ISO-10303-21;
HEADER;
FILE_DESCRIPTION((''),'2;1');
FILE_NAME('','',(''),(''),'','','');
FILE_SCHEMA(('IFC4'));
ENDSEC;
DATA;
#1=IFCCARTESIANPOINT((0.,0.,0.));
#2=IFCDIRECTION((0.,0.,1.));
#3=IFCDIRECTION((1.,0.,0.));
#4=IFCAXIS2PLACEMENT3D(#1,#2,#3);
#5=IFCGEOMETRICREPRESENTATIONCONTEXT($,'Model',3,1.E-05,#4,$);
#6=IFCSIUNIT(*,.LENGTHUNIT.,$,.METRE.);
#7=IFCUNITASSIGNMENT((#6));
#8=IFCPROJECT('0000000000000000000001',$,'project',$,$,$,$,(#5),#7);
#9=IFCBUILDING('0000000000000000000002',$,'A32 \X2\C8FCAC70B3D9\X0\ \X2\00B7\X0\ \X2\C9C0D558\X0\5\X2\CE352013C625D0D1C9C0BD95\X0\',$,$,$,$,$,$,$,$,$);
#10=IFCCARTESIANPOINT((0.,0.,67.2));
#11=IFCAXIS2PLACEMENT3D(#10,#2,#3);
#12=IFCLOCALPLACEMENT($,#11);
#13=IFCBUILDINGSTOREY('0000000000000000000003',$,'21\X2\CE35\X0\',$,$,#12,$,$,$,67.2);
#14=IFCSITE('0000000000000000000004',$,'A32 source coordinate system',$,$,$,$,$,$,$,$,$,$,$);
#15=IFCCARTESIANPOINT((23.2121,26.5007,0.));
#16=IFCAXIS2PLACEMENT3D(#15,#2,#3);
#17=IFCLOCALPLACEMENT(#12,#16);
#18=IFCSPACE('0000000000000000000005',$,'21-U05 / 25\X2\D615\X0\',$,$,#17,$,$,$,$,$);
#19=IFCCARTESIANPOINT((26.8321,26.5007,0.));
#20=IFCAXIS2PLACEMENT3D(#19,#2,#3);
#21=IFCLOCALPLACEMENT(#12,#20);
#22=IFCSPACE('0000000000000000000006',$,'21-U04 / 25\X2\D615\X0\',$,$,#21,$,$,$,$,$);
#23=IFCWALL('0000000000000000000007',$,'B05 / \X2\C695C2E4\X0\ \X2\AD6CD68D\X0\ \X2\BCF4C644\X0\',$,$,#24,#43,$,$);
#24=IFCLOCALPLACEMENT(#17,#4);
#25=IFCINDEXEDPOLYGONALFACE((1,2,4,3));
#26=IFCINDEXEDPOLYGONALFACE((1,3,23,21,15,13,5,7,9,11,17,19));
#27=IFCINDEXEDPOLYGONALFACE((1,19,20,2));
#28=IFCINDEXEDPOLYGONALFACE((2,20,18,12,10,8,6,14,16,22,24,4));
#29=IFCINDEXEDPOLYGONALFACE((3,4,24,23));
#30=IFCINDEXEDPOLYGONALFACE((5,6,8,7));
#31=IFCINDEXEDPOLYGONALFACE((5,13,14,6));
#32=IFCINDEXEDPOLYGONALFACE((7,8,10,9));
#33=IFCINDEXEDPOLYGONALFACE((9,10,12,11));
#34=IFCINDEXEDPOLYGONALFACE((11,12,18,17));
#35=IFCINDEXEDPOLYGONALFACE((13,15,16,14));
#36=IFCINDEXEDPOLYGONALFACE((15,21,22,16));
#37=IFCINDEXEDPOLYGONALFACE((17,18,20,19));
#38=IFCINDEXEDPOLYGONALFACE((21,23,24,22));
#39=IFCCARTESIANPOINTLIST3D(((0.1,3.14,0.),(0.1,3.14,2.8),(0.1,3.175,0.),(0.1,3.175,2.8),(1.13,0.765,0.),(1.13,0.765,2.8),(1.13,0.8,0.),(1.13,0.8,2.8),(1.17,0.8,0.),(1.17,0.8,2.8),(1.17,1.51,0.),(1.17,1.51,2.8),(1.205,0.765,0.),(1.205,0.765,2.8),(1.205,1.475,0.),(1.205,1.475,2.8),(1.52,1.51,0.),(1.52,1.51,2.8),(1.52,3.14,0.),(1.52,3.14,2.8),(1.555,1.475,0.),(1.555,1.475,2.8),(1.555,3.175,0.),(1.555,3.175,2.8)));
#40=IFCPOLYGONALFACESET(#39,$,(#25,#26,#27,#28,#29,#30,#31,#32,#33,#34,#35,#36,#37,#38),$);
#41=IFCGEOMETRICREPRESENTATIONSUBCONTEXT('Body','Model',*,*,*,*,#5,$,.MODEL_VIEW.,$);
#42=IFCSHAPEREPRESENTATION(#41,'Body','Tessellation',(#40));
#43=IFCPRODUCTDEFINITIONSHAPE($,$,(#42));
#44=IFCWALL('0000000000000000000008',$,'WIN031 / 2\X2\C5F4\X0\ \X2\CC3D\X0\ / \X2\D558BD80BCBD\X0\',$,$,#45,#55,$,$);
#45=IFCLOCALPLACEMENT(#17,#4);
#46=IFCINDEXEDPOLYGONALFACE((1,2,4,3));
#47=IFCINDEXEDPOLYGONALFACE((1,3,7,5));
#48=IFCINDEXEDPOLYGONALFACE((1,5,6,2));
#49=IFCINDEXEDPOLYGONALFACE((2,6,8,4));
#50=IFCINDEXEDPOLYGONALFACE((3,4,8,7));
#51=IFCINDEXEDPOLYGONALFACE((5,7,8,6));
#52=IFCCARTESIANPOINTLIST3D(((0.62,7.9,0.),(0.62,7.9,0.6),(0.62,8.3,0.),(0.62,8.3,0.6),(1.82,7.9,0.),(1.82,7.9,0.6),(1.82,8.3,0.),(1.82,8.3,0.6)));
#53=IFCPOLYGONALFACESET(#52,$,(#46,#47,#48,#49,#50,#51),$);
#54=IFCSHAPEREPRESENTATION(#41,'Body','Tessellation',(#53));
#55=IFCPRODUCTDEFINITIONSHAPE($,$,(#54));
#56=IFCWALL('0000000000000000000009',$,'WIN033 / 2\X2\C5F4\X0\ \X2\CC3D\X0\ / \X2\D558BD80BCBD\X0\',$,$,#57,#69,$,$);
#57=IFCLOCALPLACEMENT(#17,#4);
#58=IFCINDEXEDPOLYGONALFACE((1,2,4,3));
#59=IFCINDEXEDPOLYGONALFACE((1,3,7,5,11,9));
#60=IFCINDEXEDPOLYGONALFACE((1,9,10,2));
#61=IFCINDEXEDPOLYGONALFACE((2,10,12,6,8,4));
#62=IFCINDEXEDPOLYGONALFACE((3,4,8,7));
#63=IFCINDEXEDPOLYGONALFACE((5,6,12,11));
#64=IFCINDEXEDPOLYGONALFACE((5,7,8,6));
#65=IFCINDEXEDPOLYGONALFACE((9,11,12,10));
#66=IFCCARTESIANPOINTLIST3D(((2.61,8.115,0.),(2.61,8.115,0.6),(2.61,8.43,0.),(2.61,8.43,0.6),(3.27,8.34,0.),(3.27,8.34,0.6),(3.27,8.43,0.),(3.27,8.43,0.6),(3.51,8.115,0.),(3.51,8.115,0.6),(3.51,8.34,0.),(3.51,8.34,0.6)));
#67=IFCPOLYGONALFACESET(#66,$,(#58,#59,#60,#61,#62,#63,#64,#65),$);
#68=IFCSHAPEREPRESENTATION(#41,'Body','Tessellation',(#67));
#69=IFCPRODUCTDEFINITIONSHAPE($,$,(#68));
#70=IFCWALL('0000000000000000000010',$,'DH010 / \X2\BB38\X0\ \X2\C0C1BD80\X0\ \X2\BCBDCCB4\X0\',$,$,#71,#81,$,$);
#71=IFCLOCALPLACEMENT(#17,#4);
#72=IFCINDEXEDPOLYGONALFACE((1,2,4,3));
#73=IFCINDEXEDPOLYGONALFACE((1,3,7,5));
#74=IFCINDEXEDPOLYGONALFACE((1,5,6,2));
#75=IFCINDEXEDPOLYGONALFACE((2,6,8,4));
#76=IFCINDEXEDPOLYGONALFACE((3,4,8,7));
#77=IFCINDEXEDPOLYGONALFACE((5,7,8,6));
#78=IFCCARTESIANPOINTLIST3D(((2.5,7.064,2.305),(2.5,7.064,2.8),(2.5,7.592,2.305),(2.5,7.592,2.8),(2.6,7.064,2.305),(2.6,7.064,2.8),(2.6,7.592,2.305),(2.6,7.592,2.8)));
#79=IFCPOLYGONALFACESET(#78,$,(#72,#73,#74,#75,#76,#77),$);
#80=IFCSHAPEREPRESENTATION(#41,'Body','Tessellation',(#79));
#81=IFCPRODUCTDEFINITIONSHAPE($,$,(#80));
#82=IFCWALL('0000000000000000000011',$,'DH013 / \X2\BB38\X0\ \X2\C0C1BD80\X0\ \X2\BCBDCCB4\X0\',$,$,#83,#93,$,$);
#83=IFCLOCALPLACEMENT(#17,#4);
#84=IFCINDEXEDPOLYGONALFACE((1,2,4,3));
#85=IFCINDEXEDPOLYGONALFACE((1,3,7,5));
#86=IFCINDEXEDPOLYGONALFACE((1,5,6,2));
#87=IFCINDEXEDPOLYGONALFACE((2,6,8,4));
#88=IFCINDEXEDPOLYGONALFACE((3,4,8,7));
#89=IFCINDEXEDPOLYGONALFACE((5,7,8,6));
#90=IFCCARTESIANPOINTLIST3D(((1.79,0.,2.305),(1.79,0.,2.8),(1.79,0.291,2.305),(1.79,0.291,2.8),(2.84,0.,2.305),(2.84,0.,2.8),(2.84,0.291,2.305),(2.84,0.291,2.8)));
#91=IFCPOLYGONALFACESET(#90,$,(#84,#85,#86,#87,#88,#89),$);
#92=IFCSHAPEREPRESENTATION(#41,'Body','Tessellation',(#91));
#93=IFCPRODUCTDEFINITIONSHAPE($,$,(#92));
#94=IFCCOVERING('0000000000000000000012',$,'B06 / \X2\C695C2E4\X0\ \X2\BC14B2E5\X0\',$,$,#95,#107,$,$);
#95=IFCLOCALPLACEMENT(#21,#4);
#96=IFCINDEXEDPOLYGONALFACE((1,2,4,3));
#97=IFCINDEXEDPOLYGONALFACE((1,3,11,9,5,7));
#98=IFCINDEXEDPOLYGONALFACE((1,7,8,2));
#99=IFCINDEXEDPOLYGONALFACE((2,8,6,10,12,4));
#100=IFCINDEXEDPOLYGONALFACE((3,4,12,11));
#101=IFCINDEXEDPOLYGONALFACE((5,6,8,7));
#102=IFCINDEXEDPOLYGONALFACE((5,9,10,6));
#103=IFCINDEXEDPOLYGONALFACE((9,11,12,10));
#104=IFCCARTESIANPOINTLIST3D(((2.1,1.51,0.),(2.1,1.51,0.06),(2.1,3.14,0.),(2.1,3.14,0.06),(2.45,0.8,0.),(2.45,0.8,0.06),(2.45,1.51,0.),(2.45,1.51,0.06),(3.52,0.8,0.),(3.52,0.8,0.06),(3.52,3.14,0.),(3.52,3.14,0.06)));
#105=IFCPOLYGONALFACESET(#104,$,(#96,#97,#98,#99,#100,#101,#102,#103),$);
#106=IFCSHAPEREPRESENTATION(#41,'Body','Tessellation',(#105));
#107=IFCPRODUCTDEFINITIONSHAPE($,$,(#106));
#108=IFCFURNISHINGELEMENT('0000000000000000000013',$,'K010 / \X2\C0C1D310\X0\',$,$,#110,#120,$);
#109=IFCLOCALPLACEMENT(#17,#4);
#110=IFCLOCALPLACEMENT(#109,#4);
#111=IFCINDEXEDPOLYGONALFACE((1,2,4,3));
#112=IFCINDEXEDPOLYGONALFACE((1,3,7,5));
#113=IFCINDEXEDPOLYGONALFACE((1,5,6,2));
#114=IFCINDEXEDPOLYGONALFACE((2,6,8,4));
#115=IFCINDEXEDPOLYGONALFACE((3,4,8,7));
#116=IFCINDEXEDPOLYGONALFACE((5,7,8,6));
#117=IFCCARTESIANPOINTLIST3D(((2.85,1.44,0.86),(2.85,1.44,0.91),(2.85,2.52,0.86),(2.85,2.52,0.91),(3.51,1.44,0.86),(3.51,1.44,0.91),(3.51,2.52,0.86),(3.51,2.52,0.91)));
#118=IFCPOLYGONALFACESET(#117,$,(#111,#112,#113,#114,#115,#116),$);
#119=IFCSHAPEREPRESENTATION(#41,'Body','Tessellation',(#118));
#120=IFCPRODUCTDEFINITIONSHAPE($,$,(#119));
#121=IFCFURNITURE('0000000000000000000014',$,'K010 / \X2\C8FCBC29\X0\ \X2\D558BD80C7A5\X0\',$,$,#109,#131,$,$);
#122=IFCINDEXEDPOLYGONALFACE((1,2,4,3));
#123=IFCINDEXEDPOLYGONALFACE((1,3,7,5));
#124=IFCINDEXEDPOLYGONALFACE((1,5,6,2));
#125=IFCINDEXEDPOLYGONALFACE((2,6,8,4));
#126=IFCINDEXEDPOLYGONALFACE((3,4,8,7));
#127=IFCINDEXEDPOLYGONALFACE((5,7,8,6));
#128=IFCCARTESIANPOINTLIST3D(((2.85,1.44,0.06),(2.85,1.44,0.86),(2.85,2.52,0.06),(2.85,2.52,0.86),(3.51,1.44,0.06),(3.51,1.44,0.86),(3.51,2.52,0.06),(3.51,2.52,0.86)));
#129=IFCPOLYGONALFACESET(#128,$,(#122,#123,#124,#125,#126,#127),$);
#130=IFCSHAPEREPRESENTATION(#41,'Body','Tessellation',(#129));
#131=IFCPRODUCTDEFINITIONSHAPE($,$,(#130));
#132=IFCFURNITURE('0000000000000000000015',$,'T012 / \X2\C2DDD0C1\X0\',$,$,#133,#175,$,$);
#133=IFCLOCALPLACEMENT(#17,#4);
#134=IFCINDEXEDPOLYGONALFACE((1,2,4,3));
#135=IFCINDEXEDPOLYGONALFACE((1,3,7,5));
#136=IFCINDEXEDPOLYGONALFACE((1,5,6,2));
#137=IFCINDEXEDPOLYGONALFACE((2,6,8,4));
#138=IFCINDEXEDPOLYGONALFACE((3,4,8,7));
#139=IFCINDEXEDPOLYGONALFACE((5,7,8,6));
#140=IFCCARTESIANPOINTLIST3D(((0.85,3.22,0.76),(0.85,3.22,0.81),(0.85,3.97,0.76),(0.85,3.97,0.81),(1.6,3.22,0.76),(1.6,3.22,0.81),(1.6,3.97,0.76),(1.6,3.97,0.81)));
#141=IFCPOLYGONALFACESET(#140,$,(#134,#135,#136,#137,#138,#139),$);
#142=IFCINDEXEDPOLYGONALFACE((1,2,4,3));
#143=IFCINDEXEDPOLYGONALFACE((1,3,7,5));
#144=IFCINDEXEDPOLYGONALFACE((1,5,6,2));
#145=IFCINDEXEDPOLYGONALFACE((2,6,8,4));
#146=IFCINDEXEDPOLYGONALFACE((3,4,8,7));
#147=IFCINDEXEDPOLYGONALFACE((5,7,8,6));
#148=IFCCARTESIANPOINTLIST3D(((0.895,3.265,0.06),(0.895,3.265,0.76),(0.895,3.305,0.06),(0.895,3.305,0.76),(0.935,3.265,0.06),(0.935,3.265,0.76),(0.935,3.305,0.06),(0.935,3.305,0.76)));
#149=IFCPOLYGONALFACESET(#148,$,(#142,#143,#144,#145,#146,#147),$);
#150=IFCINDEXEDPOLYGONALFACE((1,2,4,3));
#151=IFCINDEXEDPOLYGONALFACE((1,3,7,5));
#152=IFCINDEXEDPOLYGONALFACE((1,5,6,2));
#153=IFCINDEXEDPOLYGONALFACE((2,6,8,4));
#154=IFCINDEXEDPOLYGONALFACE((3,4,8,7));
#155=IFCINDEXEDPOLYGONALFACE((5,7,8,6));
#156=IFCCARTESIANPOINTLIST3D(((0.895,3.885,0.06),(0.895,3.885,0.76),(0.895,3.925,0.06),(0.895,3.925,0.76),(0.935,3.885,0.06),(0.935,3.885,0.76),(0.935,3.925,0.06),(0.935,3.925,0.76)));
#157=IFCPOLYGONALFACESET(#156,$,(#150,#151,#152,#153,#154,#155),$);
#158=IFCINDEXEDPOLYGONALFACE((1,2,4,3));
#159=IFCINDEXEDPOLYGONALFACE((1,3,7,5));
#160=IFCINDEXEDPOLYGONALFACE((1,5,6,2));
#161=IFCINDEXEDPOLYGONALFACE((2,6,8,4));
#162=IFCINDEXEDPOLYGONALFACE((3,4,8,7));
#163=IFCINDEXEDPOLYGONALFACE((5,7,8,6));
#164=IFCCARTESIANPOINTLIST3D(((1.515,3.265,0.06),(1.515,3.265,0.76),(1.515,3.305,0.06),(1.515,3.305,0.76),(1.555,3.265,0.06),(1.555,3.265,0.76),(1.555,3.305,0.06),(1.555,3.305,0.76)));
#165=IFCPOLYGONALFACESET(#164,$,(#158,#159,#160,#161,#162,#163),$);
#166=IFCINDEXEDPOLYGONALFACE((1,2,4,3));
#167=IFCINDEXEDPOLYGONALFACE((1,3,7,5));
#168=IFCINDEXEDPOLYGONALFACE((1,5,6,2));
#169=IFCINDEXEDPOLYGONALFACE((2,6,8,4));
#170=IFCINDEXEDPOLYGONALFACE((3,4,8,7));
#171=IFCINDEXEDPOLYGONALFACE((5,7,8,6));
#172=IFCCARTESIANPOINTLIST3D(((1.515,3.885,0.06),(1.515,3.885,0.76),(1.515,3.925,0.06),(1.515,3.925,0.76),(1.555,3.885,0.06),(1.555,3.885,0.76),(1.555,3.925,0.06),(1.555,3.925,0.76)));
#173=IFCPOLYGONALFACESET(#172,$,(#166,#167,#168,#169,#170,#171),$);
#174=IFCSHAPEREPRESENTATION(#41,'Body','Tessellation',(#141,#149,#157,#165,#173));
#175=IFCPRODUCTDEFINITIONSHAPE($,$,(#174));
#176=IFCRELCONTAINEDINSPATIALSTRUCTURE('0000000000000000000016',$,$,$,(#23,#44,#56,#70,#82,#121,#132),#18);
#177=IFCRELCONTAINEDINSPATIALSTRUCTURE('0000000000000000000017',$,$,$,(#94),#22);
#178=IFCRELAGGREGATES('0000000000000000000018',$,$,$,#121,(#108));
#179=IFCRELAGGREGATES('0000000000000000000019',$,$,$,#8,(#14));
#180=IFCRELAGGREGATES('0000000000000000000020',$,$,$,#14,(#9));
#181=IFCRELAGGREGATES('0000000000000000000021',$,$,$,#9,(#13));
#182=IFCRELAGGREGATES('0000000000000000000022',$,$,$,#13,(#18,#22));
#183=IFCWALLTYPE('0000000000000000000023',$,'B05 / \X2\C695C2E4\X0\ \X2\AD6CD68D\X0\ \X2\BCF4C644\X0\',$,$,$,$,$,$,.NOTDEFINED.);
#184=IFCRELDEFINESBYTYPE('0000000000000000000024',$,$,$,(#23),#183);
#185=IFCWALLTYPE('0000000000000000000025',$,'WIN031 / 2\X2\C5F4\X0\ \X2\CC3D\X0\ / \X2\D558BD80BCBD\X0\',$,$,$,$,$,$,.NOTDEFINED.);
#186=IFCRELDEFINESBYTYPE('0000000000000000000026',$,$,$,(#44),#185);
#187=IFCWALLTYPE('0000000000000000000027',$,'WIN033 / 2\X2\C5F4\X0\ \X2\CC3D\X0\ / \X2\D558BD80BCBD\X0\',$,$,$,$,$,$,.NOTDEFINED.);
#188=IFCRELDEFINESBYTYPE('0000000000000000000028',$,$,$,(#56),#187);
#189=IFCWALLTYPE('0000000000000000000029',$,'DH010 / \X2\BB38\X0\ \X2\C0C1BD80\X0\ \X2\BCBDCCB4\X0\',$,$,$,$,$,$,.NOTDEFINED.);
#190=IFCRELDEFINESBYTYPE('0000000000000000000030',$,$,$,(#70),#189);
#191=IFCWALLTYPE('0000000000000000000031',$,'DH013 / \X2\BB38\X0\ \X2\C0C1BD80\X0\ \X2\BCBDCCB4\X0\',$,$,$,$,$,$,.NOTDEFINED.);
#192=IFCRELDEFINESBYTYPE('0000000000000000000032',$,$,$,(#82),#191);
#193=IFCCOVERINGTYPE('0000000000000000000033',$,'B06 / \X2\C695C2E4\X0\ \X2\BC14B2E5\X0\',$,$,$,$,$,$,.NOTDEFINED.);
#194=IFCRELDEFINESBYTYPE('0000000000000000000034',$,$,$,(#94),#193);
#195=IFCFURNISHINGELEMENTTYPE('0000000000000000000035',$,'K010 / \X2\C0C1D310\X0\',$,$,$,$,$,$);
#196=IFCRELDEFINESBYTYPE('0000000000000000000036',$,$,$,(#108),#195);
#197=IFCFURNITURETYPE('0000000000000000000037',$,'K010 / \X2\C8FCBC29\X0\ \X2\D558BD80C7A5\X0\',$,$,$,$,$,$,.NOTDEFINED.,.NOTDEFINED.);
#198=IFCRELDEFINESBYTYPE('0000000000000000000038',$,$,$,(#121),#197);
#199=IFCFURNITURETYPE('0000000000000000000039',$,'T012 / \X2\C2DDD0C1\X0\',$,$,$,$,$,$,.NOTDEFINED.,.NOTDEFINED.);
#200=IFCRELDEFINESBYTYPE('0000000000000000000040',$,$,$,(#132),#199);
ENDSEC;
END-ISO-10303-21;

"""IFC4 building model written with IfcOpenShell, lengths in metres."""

from ifc_helpers import new_model, si_unit, frame, origin, origin_with_axes, place, context, subcontext, project, spatial, polyline, outline, extrude, source, transform, mapped, type_object, type_shapes, element, aggregate, save


model = new_model("IFC4")

# Units and contexts
model_context = context("Model", 3, precision=1e-05, world=origin_with_axes())
body_context = subcontext(model_context, "Body", "Model", "MODEL_VIEW")
ifc_project = project(units=[si_unit("LENGTHUNIT", "METRE")], contexts=[model_context])

# Site, building, storey, space
site = spatial("IfcSite", under=ifc_project, Name="A32 source coordinate system")
building = spatial("IfcBuilding", under=site, Name="A32 주거동 · 지하5층–옥탑지붕")
storey_placement = place(None, frame((0.0, 0.0, 67.2), z_axis=(0.0, 0.0, 1.0), x_axis=(1.0, 0.0, 0.0)))
storey = spatial("IfcBuildingStorey", under=building, at=storey_placement, Name="21층", Elevation=67.2)
space_1_placement = place(storey_placement, frame((23.2121, 26.5007, 0.0), z_axis=(0.0, 0.0, 1.0), x_axis=(1.0, 0.0, 0.0)))
space_1 = spatial("IfcSpace", under=storey, at=space_1_placement, Name="21-U05 / 25형")

# Walls
wall_type_1 = type_object("IfcWallType", Name="B05 / 욕실 구획 보완", PredefinedType="NOTDEFINED")
shared_shape_1 = source(origin(), body_context, "Body", "SweptSolid", [
    extrude(outline(polyline([(1.17, 1.51), (1.52, 1.51), (1.52, 3.14), (0.1, 3.14), (0.1, 3.175), (1.555, 3.175), (1.555, 1.475), (1.205, 1.475), (1.205, 0.765), (1.13, 0.765), (1.13, 0.8), (1.17, 0.8), (1.17, 1.51)])), origin(), (0.0, 0.0, 1.0), 2.8),
])
type_shapes(wall_type_1, [shared_shape_1])
wall_1_placement = place(space_1_placement, origin_with_axes())
element("IfcWall", 1, at=wall_1_placement, inside=space_1, type_object=wall_type_1, Name="B05 / 욕실 구획 보완", context=body_context, shape_type="MappedRepresentation", body=[
    mapped(shared_shape_1, transform((0.0, 0.0, 0.0), scale=1.0)),
])
wall_type_2 = type_object("IfcWallType", Name="WIN031 / 2열 창 / 하부벽", PredefinedType="NOTDEFINED")
shared_shape_2 = source(origin(), body_context, "Body", "SweptSolid", [
    extrude(outline(polyline([(0.62, 8.3), (1.82, 8.3), (1.82, 7.9), (0.62, 7.9), (0.62, 8.3)])), origin(), (0.0, 0.0, 1.0), 0.6),
])
type_shapes(wall_type_2, [shared_shape_2])
wall_2_placement = place(space_1_placement, origin_with_axes())
element("IfcWall", 2, at=wall_2_placement, inside=space_1, type_object=wall_type_2, Name="WIN031 / 2열 창 / 하부벽", context=body_context, shape_type="MappedRepresentation", body=[
    mapped(shared_shape_2, transform((0.0, 0.0, 0.0), scale=1.0)),
])
wall_type_3 = type_object("IfcWallType", Name="WIN033 / 2열 창 / 하부벽", PredefinedType="NOTDEFINED")
shared_shape_3 = source(origin(), body_context, "Body", "SweptSolid", [
    extrude(outline(polyline([(2.61, 8.43), (3.27, 8.43), (3.27, 8.34), (3.51, 8.34), (3.51, 8.115), (2.61, 8.115), (2.61, 8.43)])), origin(), (0.0, 0.0, 1.0), 0.6),
])
type_shapes(wall_type_3, [shared_shape_3])
wall_3_placement = place(space_1_placement, origin_with_axes())
element("IfcWall", 3, at=wall_3_placement, inside=space_1, type_object=wall_type_3, Name="WIN033 / 2열 창 / 하부벽", context=body_context, shape_type="MappedRepresentation", body=[
    mapped(shared_shape_3, transform((0.0, 0.0, 0.0), scale=1.0)),
])
wall_type_4 = type_object("IfcWallType", Name="DH010 / 문 상부 벽체", PredefinedType="NOTDEFINED")
shared_shape_4 = source(origin(), body_context, "Body", "SweptSolid", [
    extrude(outline(polyline([(2.5, 7.592), (2.6, 7.592), (2.6, 7.064), (2.5, 7.064), (2.5, 7.592)])), frame((0.0, 0.0, 2.305)), (0.0, 0.0, 1.0), 0.495),
])
type_shapes(wall_type_4, [shared_shape_4])
wall_4_placement = place(space_1_placement, origin_with_axes())
element("IfcWall", 4, at=wall_4_placement, inside=space_1, type_object=wall_type_4, Name="DH010 / 문 상부 벽체", context=body_context, shape_type="MappedRepresentation", body=[
    mapped(shared_shape_4, transform((0.0, 0.0, 0.0), scale=1.0)),
])
wall_type_5 = type_object("IfcWallType", Name="DH013 / 문 상부 벽체", PredefinedType="NOTDEFINED")
shared_shape_5 = source(origin(), body_context, "Body", "SweptSolid", [
    extrude(outline(polyline([(2.84, 0.291), (2.84, 0.0), (1.79, 0.0), (1.79, 0.291), (2.84, 0.291)])), frame((0.0, 0.0, 2.305)), (0.0, 0.0, 1.0), 0.495),
])
type_shapes(wall_type_5, [shared_shape_5])
wall_5_placement = place(space_1_placement, origin_with_axes())
element("IfcWall", 5, at=wall_5_placement, inside=space_1, type_object=wall_type_5, Name="DH013 / 문 상부 벽체", context=body_context, shape_type="MappedRepresentation", body=[
    mapped(shared_shape_5, transform((0.0, 0.0, 0.0), scale=1.0)),
])

# Shared definitions
space_2_placement = place(storey_placement, frame((26.8321, 26.5007, 0.0), z_axis=(0.0, 0.0, 1.0), x_axis=(1.0, 0.0, 0.0)))
space_2 = spatial("IfcSpace", under=storey, at=space_2_placement, Name="21-U04 / 25형")

# Covering
covering_type = type_object("IfcCoveringType", Name="B06 / 욕실 바닥", PredefinedType="NOTDEFINED")
shared_shape_6 = source(origin(), body_context, "Body", "SweptSolid", [
    extrude(outline(polyline([(2.1, 3.14), (3.52, 3.14), (3.52, 0.8), (2.45, 0.8), (2.45, 1.51), (2.1, 1.51), (2.1, 3.14)])), origin(), (0.0, 0.0, 1.0), 0.06),
])
type_shapes(covering_type, [shared_shape_6])
covering_placement = place(space_2_placement, origin_with_axes())
element("IfcCovering", 6, at=covering_placement, inside=space_2, type_object=covering_type, Name="B06 / 욕실 바닥", context=body_context, shape_type="MappedRepresentation", body=[
    mapped(shared_shape_6, transform((0.0, 0.0, 0.0), scale=1.0)),
])

# Furnishing element
furnishing_element_type_1 = type_object("IfcFurnishingElementType", Name="K010 / 상판")
shared_shape_7 = source(origin(), body_context, "Body", "SweptSolid", [
    extrude(outline(polyline([(2.85, 2.52), (3.51, 2.52), (3.51, 1.44), (2.85, 1.44), (2.85, 2.52)])), frame((0.0, 0.0, 0.86)), (0.0, 0.0, 1.0), 0.05),
])
type_shapes(furnishing_element_type_1, [shared_shape_7])
furniture_1_placement = place(space_1_placement, origin_with_axes())
furnishing_1_placement = place(furniture_1_placement, origin_with_axes())
furnishing_1 = element("IfcFurnishingElement", 7, at=furnishing_1_placement, type_object=furnishing_element_type_1, Name="K010 / 상판", context=body_context, shape_type="MappedRepresentation", body=[
    mapped(shared_shape_7, transform((0.0, 0.0, 0.0), scale=1.0)),
])

# Furniture
furniture_type_1 = type_object("IfcFurnitureType", Name="K010 / 주방 하부장", AssemblyPlace="NOTDEFINED", PredefinedType="NOTDEFINED")
shared_shape_8 = source(origin(), body_context, "Body", "SweptSolid", [
    extrude(outline(polyline([(2.85, 1.44), (2.85, 2.52), (3.51, 2.52), (3.51, 1.44), (2.85, 1.44)])), frame((0.0, 0.0, 0.06)), (0.0, 0.0, 1.0), 0.8),
])
type_shapes(furniture_type_1, [shared_shape_8])
furniture_1 = element("IfcFurniture", 8, at=furniture_1_placement, inside=space_1, type_object=furniture_type_1, Name="K010 / 주방 하부장", context=body_context, shape_type="MappedRepresentation", body=[
    mapped(shared_shape_8, transform((0.0, 0.0, 0.0), scale=1.0)),
])
aggregate(furniture_1, [furnishing_1])
furniture_type_2 = type_object("IfcFurnitureType", Name="T012 / 식탁", AssemblyPlace="NOTDEFINED", PredefinedType="NOTDEFINED")
shared_shape_9 = source(origin(), body_context, "Body", "SweptSolid", [
    extrude(outline(polyline([(1.6, 3.97), (1.6, 3.22), (0.85, 3.22), (0.85, 3.97), (1.6, 3.97)])), frame((0.0, 0.0, 0.76)), (0.0, 0.0, 1.0), 0.05),
    extrude(outline(polyline([(0.895, 3.265), (0.895, 3.305), (0.935, 3.305), (0.935, 3.265), (0.895, 3.265)])), frame((0.0, 0.0, 0.06)), (0.0, 0.0, 1.0), 0.7),
    extrude(outline(polyline([(0.895, 3.885), (0.895, 3.925), (0.935, 3.925), (0.935, 3.885), (0.895, 3.885)])), frame((0.0, 0.0, 0.06)), (0.0, 0.0, 1.0), 0.7),
    extrude(outline(polyline([(1.515, 3.265), (1.515, 3.305), (1.555, 3.305), (1.555, 3.265), (1.515, 3.265)])), frame((0.0, 0.0, 0.06)), (0.0, 0.0, 1.0), 0.7),
    extrude(outline(polyline([(1.515, 3.885), (1.515, 3.925), (1.555, 3.925), (1.555, 3.885), (1.515, 3.885)])), frame((0.0, 0.0, 0.06)), (0.0, 0.0, 1.0), 0.7),
])
type_shapes(furniture_type_2, [shared_shape_9])
furniture_2_placement = place(space_1_placement, origin_with_axes())
element("IfcFurniture", 9, at=furniture_2_placement, inside=space_1, type_object=furniture_type_2, Name="T012 / 식탁", context=body_context, shape_type="MappedRepresentation", body=[
    mapped(shared_shape_9, transform((0.0, 0.0, 0.0), scale=1.0)),
])

save(model, "model.ifc")
